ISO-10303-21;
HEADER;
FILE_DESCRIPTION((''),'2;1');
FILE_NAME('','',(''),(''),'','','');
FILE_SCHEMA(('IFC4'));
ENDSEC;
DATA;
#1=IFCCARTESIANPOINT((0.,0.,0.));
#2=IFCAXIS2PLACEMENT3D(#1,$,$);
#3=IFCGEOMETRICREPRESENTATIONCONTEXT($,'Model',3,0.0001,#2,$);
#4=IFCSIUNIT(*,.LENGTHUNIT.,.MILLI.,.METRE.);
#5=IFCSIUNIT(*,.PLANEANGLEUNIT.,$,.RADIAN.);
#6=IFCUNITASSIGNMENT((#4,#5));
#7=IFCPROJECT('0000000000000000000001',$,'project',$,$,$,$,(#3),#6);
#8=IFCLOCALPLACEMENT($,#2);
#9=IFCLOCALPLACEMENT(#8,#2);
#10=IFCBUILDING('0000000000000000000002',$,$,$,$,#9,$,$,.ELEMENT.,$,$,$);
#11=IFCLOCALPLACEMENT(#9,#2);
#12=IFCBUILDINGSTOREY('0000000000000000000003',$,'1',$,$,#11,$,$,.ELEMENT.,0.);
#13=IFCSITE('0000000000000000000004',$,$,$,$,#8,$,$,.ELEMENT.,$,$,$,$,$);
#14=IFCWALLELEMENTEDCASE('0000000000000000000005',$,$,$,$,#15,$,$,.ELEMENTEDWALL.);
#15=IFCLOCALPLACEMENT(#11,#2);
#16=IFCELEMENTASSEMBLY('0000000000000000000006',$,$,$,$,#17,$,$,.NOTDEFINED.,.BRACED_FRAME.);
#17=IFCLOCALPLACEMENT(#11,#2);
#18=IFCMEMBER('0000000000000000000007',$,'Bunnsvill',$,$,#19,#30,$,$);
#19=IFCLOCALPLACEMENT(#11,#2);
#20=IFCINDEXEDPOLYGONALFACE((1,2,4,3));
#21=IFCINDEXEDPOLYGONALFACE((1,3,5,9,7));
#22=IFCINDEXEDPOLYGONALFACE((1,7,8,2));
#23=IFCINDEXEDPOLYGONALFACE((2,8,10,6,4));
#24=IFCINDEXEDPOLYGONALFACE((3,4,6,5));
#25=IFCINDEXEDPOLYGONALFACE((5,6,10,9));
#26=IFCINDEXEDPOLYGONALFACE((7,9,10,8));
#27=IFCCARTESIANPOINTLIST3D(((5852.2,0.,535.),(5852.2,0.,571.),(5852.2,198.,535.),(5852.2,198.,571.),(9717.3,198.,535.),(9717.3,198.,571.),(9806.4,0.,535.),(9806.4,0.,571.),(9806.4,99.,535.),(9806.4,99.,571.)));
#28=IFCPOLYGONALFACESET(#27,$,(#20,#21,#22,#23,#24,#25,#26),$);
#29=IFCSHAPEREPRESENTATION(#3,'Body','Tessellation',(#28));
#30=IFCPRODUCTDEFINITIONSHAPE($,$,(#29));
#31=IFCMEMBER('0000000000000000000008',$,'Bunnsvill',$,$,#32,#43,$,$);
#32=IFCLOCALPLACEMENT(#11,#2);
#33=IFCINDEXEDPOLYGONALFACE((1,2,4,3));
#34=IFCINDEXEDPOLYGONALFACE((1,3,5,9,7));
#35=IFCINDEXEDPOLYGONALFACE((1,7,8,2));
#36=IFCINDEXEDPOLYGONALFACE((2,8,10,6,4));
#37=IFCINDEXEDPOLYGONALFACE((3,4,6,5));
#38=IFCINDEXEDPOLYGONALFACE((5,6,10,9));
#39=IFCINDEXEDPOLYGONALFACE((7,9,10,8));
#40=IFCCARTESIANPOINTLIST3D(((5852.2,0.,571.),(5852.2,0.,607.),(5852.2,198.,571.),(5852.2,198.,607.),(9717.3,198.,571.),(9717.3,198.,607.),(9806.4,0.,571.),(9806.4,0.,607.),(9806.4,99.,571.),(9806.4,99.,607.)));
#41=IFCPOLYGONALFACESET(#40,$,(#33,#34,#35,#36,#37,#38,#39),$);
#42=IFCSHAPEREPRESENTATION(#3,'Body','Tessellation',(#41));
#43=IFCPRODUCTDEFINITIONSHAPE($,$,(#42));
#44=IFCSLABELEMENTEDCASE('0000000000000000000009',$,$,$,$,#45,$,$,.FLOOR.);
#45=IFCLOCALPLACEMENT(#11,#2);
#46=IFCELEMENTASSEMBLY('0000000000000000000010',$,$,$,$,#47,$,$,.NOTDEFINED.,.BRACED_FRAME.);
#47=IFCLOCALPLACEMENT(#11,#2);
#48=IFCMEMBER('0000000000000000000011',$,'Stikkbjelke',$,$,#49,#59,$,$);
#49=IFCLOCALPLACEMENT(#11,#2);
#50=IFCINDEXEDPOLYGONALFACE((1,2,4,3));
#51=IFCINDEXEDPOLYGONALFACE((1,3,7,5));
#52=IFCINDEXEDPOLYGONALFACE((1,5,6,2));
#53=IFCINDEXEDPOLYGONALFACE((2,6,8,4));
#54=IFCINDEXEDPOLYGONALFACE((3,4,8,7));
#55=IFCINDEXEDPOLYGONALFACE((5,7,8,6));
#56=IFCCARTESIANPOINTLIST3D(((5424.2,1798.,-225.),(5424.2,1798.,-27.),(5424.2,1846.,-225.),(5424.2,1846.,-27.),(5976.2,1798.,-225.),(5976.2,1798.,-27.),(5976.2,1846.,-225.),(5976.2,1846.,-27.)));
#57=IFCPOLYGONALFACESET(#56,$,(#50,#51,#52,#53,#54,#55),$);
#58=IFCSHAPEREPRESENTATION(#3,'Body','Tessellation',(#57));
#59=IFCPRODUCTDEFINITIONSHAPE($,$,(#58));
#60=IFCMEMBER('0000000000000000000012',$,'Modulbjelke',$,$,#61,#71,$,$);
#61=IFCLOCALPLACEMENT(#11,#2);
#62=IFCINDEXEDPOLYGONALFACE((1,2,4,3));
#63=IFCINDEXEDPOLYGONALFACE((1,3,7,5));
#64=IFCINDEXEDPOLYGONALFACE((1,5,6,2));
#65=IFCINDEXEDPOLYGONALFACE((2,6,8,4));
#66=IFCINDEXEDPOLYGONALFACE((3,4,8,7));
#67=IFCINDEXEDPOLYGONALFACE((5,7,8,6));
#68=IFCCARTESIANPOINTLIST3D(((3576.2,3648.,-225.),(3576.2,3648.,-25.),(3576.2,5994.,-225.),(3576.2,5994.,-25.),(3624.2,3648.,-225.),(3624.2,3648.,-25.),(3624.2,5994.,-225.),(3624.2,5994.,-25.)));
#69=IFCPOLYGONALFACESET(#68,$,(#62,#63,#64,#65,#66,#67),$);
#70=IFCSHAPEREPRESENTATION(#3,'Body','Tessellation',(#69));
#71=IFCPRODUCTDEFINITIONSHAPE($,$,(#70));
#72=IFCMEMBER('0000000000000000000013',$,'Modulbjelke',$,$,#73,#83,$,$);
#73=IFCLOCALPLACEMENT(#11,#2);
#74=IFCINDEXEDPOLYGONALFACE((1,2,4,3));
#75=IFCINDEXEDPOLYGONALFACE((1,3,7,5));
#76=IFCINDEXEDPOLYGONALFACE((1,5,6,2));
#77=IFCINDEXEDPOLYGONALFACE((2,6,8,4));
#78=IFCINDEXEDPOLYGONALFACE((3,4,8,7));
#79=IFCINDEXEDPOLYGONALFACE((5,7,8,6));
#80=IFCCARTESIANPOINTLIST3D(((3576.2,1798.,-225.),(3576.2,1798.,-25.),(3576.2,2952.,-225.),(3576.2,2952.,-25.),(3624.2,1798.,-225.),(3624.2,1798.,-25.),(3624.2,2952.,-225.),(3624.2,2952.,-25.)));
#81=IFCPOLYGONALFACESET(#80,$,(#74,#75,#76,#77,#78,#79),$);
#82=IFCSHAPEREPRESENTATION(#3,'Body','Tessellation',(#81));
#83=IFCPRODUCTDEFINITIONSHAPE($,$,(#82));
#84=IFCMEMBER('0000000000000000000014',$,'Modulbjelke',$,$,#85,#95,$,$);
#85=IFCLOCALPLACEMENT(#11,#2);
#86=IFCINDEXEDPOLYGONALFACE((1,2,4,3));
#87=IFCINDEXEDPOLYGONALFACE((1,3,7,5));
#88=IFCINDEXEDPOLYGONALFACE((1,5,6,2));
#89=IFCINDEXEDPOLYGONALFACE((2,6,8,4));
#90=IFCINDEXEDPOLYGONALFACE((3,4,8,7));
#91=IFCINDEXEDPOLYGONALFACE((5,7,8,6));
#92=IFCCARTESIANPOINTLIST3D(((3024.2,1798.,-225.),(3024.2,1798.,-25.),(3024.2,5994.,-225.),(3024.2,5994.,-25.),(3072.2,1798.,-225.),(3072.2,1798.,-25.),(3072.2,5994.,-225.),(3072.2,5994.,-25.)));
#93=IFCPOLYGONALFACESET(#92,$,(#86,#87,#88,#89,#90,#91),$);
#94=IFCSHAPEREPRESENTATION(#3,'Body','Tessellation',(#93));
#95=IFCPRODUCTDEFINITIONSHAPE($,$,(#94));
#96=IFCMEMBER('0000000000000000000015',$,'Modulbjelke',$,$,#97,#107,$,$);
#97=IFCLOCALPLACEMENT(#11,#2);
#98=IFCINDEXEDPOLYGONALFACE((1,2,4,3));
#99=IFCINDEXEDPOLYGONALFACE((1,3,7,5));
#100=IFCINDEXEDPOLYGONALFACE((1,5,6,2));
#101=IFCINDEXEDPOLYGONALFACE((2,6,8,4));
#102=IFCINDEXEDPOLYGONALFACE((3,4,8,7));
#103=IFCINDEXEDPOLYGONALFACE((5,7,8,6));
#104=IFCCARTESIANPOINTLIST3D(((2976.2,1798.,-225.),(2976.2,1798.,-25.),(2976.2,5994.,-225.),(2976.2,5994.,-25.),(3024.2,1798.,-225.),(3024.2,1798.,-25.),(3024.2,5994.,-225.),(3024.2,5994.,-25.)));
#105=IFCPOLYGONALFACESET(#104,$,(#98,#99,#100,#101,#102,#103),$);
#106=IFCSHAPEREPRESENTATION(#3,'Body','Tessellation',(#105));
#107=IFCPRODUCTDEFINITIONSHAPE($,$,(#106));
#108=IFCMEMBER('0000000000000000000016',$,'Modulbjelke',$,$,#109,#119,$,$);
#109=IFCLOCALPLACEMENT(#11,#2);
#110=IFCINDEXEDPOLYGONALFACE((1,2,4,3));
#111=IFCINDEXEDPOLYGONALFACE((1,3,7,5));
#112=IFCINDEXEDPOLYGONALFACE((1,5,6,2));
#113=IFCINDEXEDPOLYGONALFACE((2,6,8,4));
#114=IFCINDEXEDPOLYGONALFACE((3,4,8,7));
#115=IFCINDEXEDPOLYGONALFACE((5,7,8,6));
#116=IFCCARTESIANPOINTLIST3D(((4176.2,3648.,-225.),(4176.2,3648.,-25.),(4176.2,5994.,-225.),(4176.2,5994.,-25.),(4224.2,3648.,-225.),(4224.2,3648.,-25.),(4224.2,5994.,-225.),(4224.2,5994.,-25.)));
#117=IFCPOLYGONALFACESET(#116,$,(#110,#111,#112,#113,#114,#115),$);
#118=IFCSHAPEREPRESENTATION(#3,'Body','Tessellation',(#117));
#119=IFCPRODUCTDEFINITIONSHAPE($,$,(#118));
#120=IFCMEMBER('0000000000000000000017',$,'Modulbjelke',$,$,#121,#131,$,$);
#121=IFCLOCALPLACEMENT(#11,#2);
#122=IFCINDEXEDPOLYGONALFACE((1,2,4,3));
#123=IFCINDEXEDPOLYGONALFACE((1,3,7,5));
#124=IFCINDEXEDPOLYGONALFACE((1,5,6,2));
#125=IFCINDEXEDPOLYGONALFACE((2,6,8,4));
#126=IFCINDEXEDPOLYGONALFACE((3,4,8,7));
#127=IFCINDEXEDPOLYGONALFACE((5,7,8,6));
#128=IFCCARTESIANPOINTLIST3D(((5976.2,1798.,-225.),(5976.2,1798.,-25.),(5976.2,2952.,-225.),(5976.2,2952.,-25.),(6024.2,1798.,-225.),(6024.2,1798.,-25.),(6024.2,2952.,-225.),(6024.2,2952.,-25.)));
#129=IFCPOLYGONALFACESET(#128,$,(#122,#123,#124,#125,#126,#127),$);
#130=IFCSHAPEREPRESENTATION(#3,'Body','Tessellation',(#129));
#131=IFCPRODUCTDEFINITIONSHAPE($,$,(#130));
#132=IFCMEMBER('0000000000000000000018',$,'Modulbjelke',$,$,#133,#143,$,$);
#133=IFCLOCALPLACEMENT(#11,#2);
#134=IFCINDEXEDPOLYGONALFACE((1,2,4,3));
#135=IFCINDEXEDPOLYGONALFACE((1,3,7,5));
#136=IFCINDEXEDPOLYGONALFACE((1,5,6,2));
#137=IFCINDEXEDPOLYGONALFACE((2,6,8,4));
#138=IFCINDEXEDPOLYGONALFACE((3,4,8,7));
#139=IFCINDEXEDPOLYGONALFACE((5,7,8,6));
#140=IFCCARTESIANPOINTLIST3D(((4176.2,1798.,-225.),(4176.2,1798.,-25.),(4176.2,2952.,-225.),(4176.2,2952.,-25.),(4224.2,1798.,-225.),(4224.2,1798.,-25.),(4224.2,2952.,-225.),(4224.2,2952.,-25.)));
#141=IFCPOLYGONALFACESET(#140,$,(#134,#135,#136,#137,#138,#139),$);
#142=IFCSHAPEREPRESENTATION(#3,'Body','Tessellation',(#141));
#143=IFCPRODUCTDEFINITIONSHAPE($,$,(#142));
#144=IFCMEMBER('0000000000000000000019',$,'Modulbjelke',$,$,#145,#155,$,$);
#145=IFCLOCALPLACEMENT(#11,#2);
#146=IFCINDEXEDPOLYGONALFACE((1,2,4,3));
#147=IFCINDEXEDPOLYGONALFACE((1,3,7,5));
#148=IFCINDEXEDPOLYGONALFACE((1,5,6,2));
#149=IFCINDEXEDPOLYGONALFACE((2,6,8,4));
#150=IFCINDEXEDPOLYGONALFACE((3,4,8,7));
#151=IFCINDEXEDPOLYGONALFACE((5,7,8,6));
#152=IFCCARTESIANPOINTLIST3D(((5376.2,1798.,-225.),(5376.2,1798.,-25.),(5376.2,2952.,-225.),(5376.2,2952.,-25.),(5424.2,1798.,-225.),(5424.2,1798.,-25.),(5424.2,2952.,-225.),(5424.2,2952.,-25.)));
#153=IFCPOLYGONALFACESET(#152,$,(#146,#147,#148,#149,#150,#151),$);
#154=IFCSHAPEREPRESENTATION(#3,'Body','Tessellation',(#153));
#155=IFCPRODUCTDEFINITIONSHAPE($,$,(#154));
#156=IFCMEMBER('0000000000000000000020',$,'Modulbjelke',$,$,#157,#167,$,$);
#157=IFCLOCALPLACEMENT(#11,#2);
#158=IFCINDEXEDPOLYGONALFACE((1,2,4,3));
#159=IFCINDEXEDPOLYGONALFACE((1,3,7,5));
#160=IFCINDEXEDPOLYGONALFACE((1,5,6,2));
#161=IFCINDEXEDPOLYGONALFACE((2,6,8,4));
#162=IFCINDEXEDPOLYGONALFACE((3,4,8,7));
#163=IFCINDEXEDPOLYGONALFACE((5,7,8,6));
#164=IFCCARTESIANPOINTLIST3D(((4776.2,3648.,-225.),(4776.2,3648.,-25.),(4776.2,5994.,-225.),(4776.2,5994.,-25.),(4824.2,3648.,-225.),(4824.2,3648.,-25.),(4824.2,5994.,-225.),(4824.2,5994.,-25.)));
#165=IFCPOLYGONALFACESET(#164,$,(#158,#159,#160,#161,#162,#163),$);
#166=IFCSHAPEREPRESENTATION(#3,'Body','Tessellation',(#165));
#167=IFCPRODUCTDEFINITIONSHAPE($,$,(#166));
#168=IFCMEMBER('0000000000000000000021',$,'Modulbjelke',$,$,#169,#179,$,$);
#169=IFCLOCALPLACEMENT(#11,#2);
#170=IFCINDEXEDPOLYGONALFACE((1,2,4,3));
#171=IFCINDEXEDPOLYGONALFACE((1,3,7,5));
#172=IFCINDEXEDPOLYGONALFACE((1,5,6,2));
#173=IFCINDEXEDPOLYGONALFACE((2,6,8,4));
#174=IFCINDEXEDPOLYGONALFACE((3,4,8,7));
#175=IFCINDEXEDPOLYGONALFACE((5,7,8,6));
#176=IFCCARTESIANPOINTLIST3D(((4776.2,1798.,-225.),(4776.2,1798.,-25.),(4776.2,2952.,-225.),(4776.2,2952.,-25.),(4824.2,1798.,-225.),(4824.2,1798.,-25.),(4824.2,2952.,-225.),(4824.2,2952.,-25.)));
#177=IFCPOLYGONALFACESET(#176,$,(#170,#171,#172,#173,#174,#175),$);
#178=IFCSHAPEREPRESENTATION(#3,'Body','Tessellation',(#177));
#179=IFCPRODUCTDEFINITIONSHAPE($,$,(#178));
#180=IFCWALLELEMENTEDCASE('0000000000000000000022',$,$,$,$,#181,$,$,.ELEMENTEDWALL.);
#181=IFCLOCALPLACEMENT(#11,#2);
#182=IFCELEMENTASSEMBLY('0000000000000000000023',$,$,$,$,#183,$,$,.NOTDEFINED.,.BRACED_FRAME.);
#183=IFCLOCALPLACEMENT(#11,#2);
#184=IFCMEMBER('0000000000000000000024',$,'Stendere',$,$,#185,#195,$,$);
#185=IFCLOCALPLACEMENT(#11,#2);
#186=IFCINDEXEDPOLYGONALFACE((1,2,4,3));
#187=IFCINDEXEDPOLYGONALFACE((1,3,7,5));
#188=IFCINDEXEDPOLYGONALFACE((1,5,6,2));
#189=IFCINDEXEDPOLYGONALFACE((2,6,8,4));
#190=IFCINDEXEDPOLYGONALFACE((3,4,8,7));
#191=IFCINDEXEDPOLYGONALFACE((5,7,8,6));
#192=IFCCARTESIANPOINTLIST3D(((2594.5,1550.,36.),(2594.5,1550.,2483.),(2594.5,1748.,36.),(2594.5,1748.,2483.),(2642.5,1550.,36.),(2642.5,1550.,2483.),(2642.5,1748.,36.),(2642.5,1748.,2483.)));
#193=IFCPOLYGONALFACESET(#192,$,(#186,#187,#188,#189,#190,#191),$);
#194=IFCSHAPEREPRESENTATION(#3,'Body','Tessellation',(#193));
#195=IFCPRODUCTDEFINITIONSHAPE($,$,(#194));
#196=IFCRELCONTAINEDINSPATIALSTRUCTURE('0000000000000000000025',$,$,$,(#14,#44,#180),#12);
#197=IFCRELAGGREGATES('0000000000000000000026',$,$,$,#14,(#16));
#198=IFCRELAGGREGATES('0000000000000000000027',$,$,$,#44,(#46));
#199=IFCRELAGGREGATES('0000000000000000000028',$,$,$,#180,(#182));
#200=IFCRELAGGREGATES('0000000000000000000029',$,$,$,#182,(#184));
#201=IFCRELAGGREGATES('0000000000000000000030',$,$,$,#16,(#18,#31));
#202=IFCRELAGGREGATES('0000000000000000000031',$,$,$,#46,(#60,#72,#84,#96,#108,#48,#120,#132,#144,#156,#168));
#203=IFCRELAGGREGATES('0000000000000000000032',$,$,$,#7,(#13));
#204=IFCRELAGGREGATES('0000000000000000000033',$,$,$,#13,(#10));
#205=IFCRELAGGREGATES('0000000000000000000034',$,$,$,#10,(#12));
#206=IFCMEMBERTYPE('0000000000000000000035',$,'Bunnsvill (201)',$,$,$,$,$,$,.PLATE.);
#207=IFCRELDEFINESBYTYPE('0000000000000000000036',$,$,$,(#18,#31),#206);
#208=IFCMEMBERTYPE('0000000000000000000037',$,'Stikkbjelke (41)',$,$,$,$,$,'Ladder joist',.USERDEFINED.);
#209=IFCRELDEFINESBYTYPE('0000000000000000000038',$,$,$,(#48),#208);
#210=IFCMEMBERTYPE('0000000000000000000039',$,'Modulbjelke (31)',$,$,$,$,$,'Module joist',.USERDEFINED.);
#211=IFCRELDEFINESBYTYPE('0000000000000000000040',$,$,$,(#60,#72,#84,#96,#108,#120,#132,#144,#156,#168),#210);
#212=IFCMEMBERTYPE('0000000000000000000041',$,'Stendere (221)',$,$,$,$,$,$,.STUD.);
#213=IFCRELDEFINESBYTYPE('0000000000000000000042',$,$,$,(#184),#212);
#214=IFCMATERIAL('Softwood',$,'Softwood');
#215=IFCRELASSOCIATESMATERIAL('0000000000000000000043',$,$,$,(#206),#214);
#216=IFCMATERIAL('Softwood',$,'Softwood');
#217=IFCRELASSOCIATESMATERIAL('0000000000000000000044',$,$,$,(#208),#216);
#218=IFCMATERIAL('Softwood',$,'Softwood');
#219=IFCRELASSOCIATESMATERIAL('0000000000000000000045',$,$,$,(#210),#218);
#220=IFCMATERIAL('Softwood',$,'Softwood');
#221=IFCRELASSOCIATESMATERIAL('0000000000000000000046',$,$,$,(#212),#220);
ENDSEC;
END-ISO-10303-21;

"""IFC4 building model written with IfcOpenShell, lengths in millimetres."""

from ifc_helpers import new_model, si_unit, frame, origin, place, context, project, spatial, rectangle, extrude, clip, halfspace, material, material_profile, profile_set, type_object, element, aggregate, save


model = new_model("IFC4")

# Units and contexts
model_context = context("Model", 3, precision=0.0001, world=origin())
ifc_project = project(units=[si_unit("LENGTHUNIT", "METRE", prefix="MILLI"), si_unit("PLANEANGLEUNIT", "RADIAN")], contexts=[model_context])

# Site, building, storey
site_placement = place(None, origin())
site = spatial("IfcSite", under=ifc_project, at=site_placement, CompositionType="ELEMENT")
building_placement = place(site_placement, origin())
building = spatial("IfcBuilding", under=site, at=building_placement, CompositionType="ELEMENT")
storey_placement = place(building_placement, origin())
storey = spatial("IfcBuildingStorey", under=building, at=storey_placement, Name="1", CompositionType="ELEMENT", Elevation=0.0)

# Wall, element assembly, members
wall_1_placement = place(storey_placement, frame((5852.2, 198.0, 535.0), z_axis=(0.0, -1.0, 0.0)))
wall_1 = element("IfcWallElementedCase", 1, at=wall_1_placement, inside=storey, PredefinedType="ELEMENTEDWALL")
assembly_1_placement = place(wall_1_placement, origin())
assembly_1 = element("IfcElementAssembly", 2, at=assembly_1_placement, AssemblyPlace="NOTDEFINED", PredefinedType="BRACED_FRAME")
aggregate(wall_1, [assembly_1])
ifc_material_1 = material(Name="Softwood", Category="Softwood")
ifc_material_profile_1 = material_profile(ifc_material_1, rectangle(XDim=36.0, YDim=198.0), Name="Bunnsvill (201)")
ifc_profile_set_1 = profile_set([ifc_material_profile_1])
member_type_1 = type_object("IfcMemberType", Name="Bunnsvill (201)", PredefinedType="PLATE", material=ifc_profile_set_1)
member_1_placement = place(assembly_1_placement, frame((0.0, 18.0, 0.0), z_axis=(1.0, 0.0, 0.0), x_axis=(0.0, 1.0, 0.0)))
member_1 = element("IfcMember", 3, at=member_1_placement, type_object=member_type_1, Name="Bunnsvill", context=model_context, shape_type="Clipping", body=[
    clip(extrude(rectangle(XDim=36.0, YDim=198.0), frame((0.0, 99.0, 0.0)), (0.0, 0.0, 1.0), 3954.3), halfspace(frame((0.0, 99.0, 3954.3), z_axis=(0.0, -0.669131, 0.743145)), False)),
])
member_2_placement = place(assembly_1_placement, frame((0.0, 54.0, 0.0), z_axis=(1.0, 0.0, 0.0), x_axis=(0.0, 1.0, 0.0)))
member_2 = element("IfcMember", 4, at=member_2_placement, type_object=member_type_1, Name="Bunnsvill", context=model_context, shape_type="Clipping", body=[
    clip(extrude(rectangle(XDim=36.0, YDim=198.0), frame((0.0, 99.0, 0.0)), (0.0, 0.0, 1.0), 3954.3), halfspace(frame((0.0, 99.0, 3954.3), z_axis=(0.0, -0.669131, 0.743145)), False)),
])

# Slab, element assembly, members
slab_placement = place(storey_placement, origin())
slab = element("IfcSlabElementedCase", 5, at=slab_placement, inside=storey, PredefinedType="FLOOR")
assembly_2_placement = place(slab_placement, frame((0.0, 0.0, -225.0)))
assembly_2 = element("IfcElementAssembly", 6, at=assembly_2_placement, AssemblyPlace="NOTDEFINED", PredefinedType="BRACED_FRAME")
aggregate(slab, [assembly_2])
ifc_material_2 = material(Name="Softwood", Category="Softwood")
ifc_material_profile_2 = material_profile(ifc_material_2, rectangle(XDim=48.0, YDim=198.0), Name="Stikkbjelke (41)")
ifc_profile_set_2 = profile_set([ifc_material_profile_2])
member_type_2 = type_object("IfcMemberType", Name="Stikkbjelke (41)", ElementType="Ladder joist", PredefinedType="USERDEFINED", material=ifc_profile_set_2)
member_3_placement = place(assembly_2_placement, frame((5424.2, 1822.0, 0.0), z_axis=(1.0, 0.0, 0.0), x_axis=(0.0, 1.0, 0.0)))
member_3 = element("IfcMember", 7, at=member_3_placement, type_object=member_type_2, Name="Stikkbjelke", context=model_context, shape_type="SweptSolid", body=[
    extrude(rectangle(XDim=48.0, YDim=198.0), frame((0.0, 99.0, 0.0)), (0.0, 0.0, 1.0), 552.0),
])
ifc_material_3 = material(Name="Softwood", Category="Softwood")
ifc_material_profile_3 = material_profile(ifc_material_3, rectangle(XDim=48.0, YDim=200.0), Name="Modulbjelke (31)")
ifc_profile_set_3 = profile_set([ifc_material_profile_3])
member_type_3 = type_object("IfcMemberType", Name="Modulbjelke (31)", ElementType="Module joist", PredefinedType="USERDEFINED", material=ifc_profile_set_3)
member_4_placement = place(assembly_2_placement, frame((3600.2, 3648.0, 0.0), z_axis=(0.0, 1.0, 0.0), x_axis=(-1.0, 0.0, 0.0)))
member_4 = element("IfcMember", 8, at=member_4_placement, type_object=member_type_3, Name="Modulbjelke", context=model_context, shape_type="SweptSolid", body=[
    extrude(rectangle(XDim=48.0, YDim=200.0), frame((0.0, 100.0, 0.0)), (0.0, 0.0, 1.0), 2346.0),
])
member_5_placement = place(assembly_2_placement, frame((3600.2, 1798.0, 0.0), z_axis=(-0.000001, 1.0, 0.0), x_axis=(-1.0, -0.000001, 0.0)))
member_5 = element("IfcMember", 9, at=member_5_placement, type_object=member_type_3, Name="Modulbjelke", context=model_context, shape_type="Clipping", body=[
    clip(clip(extrude(rectangle(XDim=48.0, YDim=200.0), frame((0.0, 100.0, 0.0)), (0.0, 0.0, 1.0), 1154.0), halfspace(frame((0.0, 100.0, 0.0)), True)), halfspace(frame((0.0, 100.0, 1154.0)), False)),
])
member_6_placement = place(assembly_2_placement, frame((3048.2, 1798.0, 0.0), z_axis=(0.0, 1.0, 0.0), x_axis=(-1.0, 0.0, 0.0)))
member_6 = element("IfcMember", 10, at=member_6_placement, type_object=member_type_3, Name="Modulbjelke", context=model_context, shape_type="Clipping", body=[
    clip(clip(extrude(rectangle(XDim=48.0, YDim=200.0), frame((0.0, 100.0, 0.0)), (0.0, 0.0, 1.0), 4196.0), halfspace(frame((0.0, 100.0, 0.0)), True)), halfspace(frame((0.0, 100.0, 4196.0)), False)),
])
member_7_placement = place(assembly_2_placement, frame((3000.2, 1798.0, 0.0), z_axis=(0.0, 1.0, 0.0), x_axis=(-1.0, 0.0, 0.0)))
member_7 = element("IfcMember", 11, at=member_7_placement, type_object=member_type_3, Name="Modulbjelke", context=model_context, shape_type="Clipping", body=[
    clip(clip(extrude(rectangle(XDim=48.0, YDim=200.0), frame((0.0, 100.0, 0.0)), (0.0, 0.0, 1.0), 4196.0), halfspace(frame((0.0, 100.0, 0.0)), True)), halfspace(frame((0.0, 100.0, 4196.0)), False)),
])
member_8_placement = place(assembly_2_placement, frame((4200.2, 3648.0, 0.0), z_axis=(0.0, 1.0, 0.0), x_axis=(-1.0, 0.0, 0.0)))
member_8 = element("IfcMember", 12, at=member_8_placement, type_object=member_type_3, Name="Modulbjelke", context=model_context, shape_type="SweptSolid", body=[
    extrude(rectangle(XDim=48.0, YDim=200.0), frame((0.0, 100.0, 0.0)), (0.0, 0.0, 1.0), 2346.0),
])
member_9_placement = place(assembly_2_placement, frame((6000.2, 1798.0, 0.0), z_axis=(-0.000001, 1.0, 0.0), x_axis=(-1.0, -0.000001, 0.0)))
member_9 = element("IfcMember", 13, at=member_9_placement, type_object=member_type_3, Name="Modulbjelke", context=model_context, shape_type="Clipping", body=[
    clip(clip(extrude(rectangle(XDim=48.0, YDim=200.0), frame((0.0, 100.0, 0.0)), (0.0, 0.0, 1.0), 1154.0), halfspace(frame((0.0, 100.0, 0.0)), True)), halfspace(frame((0.0, 100.0, 1154.0)), False)),
])
member_10_placement = place(assembly_2_placement, frame((4200.2, 1798.0, 0.0), z_axis=(-0.000001, 1.0, 0.0), x_axis=(-1.0, -0.000001, 0.0)))
member_10 = element("IfcMember", 14, at=member_10_placement, type_object=member_type_3, Name="Modulbjelke", context=model_context, shape_type="Clipping", body=[
    clip(clip(extrude(rectangle(XDim=48.0, YDim=200.0), frame((0.0, 100.0, 0.0)), (0.0, 0.0, 1.0), 1154.0), halfspace(frame((0.0, 100.0, 0.0)), True)), halfspace(frame((0.0, 100.0, 1154.0)), False)),
])
member_11_placement = place(assembly_2_placement, frame((5400.2, 1798.0, 0.0), z_axis=(-0.000001, 1.0, 0.0), x_axis=(-1.0, -0.000001, 0.0)))
member_11 = element("IfcMember", 15, at=member_11_placement, type_object=member_type_3, Name="Modulbjelke", context=model_context, shape_type="Clipping", body=[
    clip(clip(extrude(rectangle(XDim=48.0, YDim=200.0), frame((0.0, 100.0, 0.0)), (0.0, 0.0, 1.0), 1154.0), halfspace(frame((0.0, 100.0, 0.0)), True)), halfspace(frame((0.0, 100.0, 1154.0)), False)),
])
member_12_placement = place(assembly_2_placement, frame((4800.2, 3648.0, 0.0), z_axis=(0.0, 1.0, 0.0), x_axis=(-1.0, 0.0, 0.0)))
member_12 = element("IfcMember", 16, at=member_12_placement, type_object=member_type_3, Name="Modulbjelke", context=model_context, shape_type="SweptSolid", body=[
    extrude(rectangle(XDim=48.0, YDim=200.0), frame((0.0, 100.0, 0.0)), (0.0, 0.0, 1.0), 2346.0),
])
member_13_placement = place(assembly_2_placement, frame((4800.2, 1798.0, 0.0), z_axis=(-0.000001, 1.0, 0.0), x_axis=(-1.0, -0.000001, 0.0)))
member_13 = element("IfcMember", 17, at=member_13_placement, type_object=member_type_3, Name="Modulbjelke", context=model_context, shape_type="Clipping", body=[
    clip(clip(extrude(rectangle(XDim=48.0, YDim=200.0), frame((0.0, 100.0, 0.0)), (0.0, 0.0, 1.0), 1154.0), halfspace(frame((0.0, 100.0, 0.0)), True)), halfspace(frame((0.0, 100.0, 1154.0)), False)),
])

# Wall, element assembly, member
wall_2_placement = place(storey_placement, frame((-1403.2, 1748.0, 0.0), z_axis=(0.0, -1.0, 0.0)))
wall_2 = element("IfcWallElementedCase", 18, at=wall_2_placement, inside=storey, PredefinedType="ELEMENTEDWALL")
assembly_3_placement = place(wall_2_placement, origin())
assembly_3 = element("IfcElementAssembly", 19, at=assembly_3_placement, AssemblyPlace="NOTDEFINED", PredefinedType="BRACED_FRAME")
aggregate(wall_2, [assembly_3])
ifc_material_4 = material(Name="Softwood", Category="Softwood")
ifc_material_profile_4 = material_profile(ifc_material_4, rectangle(XDim=48.0, YDim=198.0), Name="Stendere (221)")
ifc_profile_set_4 = profile_set([ifc_material_profile_4])
member_type_4 = type_object("IfcMemberType", Name="Stendere (221)", PredefinedType="STUD", material=ifc_profile_set_4)
member_14_placement = place(assembly_3_placement, frame((4021.7, 36.0, 0.0), z_axis=(0.0, 1.0, 0.0), x_axis=(-1.0, 0.0, 0.0)))
member_14 = element("IfcMember", 20, at=member_14_placement, type_object=member_type_4, Name="Stendere", context=model_context, shape_type="SweptSolid", body=[
    extrude(rectangle(XDim=48.0, YDim=198.0), frame((0.0, 99.0, 0.0)), (0.0, 0.0, 1.0), 2447.0),
])
aggregate(assembly_3, [member_14])

aggregate(assembly_1, [member_1, member_2])
aggregate(assembly_2, [member_4, member_5, member_6, member_7, member_8, member_3, member_9, member_10, member_11, member_12, member_13])

save(model, "model.ifc")
